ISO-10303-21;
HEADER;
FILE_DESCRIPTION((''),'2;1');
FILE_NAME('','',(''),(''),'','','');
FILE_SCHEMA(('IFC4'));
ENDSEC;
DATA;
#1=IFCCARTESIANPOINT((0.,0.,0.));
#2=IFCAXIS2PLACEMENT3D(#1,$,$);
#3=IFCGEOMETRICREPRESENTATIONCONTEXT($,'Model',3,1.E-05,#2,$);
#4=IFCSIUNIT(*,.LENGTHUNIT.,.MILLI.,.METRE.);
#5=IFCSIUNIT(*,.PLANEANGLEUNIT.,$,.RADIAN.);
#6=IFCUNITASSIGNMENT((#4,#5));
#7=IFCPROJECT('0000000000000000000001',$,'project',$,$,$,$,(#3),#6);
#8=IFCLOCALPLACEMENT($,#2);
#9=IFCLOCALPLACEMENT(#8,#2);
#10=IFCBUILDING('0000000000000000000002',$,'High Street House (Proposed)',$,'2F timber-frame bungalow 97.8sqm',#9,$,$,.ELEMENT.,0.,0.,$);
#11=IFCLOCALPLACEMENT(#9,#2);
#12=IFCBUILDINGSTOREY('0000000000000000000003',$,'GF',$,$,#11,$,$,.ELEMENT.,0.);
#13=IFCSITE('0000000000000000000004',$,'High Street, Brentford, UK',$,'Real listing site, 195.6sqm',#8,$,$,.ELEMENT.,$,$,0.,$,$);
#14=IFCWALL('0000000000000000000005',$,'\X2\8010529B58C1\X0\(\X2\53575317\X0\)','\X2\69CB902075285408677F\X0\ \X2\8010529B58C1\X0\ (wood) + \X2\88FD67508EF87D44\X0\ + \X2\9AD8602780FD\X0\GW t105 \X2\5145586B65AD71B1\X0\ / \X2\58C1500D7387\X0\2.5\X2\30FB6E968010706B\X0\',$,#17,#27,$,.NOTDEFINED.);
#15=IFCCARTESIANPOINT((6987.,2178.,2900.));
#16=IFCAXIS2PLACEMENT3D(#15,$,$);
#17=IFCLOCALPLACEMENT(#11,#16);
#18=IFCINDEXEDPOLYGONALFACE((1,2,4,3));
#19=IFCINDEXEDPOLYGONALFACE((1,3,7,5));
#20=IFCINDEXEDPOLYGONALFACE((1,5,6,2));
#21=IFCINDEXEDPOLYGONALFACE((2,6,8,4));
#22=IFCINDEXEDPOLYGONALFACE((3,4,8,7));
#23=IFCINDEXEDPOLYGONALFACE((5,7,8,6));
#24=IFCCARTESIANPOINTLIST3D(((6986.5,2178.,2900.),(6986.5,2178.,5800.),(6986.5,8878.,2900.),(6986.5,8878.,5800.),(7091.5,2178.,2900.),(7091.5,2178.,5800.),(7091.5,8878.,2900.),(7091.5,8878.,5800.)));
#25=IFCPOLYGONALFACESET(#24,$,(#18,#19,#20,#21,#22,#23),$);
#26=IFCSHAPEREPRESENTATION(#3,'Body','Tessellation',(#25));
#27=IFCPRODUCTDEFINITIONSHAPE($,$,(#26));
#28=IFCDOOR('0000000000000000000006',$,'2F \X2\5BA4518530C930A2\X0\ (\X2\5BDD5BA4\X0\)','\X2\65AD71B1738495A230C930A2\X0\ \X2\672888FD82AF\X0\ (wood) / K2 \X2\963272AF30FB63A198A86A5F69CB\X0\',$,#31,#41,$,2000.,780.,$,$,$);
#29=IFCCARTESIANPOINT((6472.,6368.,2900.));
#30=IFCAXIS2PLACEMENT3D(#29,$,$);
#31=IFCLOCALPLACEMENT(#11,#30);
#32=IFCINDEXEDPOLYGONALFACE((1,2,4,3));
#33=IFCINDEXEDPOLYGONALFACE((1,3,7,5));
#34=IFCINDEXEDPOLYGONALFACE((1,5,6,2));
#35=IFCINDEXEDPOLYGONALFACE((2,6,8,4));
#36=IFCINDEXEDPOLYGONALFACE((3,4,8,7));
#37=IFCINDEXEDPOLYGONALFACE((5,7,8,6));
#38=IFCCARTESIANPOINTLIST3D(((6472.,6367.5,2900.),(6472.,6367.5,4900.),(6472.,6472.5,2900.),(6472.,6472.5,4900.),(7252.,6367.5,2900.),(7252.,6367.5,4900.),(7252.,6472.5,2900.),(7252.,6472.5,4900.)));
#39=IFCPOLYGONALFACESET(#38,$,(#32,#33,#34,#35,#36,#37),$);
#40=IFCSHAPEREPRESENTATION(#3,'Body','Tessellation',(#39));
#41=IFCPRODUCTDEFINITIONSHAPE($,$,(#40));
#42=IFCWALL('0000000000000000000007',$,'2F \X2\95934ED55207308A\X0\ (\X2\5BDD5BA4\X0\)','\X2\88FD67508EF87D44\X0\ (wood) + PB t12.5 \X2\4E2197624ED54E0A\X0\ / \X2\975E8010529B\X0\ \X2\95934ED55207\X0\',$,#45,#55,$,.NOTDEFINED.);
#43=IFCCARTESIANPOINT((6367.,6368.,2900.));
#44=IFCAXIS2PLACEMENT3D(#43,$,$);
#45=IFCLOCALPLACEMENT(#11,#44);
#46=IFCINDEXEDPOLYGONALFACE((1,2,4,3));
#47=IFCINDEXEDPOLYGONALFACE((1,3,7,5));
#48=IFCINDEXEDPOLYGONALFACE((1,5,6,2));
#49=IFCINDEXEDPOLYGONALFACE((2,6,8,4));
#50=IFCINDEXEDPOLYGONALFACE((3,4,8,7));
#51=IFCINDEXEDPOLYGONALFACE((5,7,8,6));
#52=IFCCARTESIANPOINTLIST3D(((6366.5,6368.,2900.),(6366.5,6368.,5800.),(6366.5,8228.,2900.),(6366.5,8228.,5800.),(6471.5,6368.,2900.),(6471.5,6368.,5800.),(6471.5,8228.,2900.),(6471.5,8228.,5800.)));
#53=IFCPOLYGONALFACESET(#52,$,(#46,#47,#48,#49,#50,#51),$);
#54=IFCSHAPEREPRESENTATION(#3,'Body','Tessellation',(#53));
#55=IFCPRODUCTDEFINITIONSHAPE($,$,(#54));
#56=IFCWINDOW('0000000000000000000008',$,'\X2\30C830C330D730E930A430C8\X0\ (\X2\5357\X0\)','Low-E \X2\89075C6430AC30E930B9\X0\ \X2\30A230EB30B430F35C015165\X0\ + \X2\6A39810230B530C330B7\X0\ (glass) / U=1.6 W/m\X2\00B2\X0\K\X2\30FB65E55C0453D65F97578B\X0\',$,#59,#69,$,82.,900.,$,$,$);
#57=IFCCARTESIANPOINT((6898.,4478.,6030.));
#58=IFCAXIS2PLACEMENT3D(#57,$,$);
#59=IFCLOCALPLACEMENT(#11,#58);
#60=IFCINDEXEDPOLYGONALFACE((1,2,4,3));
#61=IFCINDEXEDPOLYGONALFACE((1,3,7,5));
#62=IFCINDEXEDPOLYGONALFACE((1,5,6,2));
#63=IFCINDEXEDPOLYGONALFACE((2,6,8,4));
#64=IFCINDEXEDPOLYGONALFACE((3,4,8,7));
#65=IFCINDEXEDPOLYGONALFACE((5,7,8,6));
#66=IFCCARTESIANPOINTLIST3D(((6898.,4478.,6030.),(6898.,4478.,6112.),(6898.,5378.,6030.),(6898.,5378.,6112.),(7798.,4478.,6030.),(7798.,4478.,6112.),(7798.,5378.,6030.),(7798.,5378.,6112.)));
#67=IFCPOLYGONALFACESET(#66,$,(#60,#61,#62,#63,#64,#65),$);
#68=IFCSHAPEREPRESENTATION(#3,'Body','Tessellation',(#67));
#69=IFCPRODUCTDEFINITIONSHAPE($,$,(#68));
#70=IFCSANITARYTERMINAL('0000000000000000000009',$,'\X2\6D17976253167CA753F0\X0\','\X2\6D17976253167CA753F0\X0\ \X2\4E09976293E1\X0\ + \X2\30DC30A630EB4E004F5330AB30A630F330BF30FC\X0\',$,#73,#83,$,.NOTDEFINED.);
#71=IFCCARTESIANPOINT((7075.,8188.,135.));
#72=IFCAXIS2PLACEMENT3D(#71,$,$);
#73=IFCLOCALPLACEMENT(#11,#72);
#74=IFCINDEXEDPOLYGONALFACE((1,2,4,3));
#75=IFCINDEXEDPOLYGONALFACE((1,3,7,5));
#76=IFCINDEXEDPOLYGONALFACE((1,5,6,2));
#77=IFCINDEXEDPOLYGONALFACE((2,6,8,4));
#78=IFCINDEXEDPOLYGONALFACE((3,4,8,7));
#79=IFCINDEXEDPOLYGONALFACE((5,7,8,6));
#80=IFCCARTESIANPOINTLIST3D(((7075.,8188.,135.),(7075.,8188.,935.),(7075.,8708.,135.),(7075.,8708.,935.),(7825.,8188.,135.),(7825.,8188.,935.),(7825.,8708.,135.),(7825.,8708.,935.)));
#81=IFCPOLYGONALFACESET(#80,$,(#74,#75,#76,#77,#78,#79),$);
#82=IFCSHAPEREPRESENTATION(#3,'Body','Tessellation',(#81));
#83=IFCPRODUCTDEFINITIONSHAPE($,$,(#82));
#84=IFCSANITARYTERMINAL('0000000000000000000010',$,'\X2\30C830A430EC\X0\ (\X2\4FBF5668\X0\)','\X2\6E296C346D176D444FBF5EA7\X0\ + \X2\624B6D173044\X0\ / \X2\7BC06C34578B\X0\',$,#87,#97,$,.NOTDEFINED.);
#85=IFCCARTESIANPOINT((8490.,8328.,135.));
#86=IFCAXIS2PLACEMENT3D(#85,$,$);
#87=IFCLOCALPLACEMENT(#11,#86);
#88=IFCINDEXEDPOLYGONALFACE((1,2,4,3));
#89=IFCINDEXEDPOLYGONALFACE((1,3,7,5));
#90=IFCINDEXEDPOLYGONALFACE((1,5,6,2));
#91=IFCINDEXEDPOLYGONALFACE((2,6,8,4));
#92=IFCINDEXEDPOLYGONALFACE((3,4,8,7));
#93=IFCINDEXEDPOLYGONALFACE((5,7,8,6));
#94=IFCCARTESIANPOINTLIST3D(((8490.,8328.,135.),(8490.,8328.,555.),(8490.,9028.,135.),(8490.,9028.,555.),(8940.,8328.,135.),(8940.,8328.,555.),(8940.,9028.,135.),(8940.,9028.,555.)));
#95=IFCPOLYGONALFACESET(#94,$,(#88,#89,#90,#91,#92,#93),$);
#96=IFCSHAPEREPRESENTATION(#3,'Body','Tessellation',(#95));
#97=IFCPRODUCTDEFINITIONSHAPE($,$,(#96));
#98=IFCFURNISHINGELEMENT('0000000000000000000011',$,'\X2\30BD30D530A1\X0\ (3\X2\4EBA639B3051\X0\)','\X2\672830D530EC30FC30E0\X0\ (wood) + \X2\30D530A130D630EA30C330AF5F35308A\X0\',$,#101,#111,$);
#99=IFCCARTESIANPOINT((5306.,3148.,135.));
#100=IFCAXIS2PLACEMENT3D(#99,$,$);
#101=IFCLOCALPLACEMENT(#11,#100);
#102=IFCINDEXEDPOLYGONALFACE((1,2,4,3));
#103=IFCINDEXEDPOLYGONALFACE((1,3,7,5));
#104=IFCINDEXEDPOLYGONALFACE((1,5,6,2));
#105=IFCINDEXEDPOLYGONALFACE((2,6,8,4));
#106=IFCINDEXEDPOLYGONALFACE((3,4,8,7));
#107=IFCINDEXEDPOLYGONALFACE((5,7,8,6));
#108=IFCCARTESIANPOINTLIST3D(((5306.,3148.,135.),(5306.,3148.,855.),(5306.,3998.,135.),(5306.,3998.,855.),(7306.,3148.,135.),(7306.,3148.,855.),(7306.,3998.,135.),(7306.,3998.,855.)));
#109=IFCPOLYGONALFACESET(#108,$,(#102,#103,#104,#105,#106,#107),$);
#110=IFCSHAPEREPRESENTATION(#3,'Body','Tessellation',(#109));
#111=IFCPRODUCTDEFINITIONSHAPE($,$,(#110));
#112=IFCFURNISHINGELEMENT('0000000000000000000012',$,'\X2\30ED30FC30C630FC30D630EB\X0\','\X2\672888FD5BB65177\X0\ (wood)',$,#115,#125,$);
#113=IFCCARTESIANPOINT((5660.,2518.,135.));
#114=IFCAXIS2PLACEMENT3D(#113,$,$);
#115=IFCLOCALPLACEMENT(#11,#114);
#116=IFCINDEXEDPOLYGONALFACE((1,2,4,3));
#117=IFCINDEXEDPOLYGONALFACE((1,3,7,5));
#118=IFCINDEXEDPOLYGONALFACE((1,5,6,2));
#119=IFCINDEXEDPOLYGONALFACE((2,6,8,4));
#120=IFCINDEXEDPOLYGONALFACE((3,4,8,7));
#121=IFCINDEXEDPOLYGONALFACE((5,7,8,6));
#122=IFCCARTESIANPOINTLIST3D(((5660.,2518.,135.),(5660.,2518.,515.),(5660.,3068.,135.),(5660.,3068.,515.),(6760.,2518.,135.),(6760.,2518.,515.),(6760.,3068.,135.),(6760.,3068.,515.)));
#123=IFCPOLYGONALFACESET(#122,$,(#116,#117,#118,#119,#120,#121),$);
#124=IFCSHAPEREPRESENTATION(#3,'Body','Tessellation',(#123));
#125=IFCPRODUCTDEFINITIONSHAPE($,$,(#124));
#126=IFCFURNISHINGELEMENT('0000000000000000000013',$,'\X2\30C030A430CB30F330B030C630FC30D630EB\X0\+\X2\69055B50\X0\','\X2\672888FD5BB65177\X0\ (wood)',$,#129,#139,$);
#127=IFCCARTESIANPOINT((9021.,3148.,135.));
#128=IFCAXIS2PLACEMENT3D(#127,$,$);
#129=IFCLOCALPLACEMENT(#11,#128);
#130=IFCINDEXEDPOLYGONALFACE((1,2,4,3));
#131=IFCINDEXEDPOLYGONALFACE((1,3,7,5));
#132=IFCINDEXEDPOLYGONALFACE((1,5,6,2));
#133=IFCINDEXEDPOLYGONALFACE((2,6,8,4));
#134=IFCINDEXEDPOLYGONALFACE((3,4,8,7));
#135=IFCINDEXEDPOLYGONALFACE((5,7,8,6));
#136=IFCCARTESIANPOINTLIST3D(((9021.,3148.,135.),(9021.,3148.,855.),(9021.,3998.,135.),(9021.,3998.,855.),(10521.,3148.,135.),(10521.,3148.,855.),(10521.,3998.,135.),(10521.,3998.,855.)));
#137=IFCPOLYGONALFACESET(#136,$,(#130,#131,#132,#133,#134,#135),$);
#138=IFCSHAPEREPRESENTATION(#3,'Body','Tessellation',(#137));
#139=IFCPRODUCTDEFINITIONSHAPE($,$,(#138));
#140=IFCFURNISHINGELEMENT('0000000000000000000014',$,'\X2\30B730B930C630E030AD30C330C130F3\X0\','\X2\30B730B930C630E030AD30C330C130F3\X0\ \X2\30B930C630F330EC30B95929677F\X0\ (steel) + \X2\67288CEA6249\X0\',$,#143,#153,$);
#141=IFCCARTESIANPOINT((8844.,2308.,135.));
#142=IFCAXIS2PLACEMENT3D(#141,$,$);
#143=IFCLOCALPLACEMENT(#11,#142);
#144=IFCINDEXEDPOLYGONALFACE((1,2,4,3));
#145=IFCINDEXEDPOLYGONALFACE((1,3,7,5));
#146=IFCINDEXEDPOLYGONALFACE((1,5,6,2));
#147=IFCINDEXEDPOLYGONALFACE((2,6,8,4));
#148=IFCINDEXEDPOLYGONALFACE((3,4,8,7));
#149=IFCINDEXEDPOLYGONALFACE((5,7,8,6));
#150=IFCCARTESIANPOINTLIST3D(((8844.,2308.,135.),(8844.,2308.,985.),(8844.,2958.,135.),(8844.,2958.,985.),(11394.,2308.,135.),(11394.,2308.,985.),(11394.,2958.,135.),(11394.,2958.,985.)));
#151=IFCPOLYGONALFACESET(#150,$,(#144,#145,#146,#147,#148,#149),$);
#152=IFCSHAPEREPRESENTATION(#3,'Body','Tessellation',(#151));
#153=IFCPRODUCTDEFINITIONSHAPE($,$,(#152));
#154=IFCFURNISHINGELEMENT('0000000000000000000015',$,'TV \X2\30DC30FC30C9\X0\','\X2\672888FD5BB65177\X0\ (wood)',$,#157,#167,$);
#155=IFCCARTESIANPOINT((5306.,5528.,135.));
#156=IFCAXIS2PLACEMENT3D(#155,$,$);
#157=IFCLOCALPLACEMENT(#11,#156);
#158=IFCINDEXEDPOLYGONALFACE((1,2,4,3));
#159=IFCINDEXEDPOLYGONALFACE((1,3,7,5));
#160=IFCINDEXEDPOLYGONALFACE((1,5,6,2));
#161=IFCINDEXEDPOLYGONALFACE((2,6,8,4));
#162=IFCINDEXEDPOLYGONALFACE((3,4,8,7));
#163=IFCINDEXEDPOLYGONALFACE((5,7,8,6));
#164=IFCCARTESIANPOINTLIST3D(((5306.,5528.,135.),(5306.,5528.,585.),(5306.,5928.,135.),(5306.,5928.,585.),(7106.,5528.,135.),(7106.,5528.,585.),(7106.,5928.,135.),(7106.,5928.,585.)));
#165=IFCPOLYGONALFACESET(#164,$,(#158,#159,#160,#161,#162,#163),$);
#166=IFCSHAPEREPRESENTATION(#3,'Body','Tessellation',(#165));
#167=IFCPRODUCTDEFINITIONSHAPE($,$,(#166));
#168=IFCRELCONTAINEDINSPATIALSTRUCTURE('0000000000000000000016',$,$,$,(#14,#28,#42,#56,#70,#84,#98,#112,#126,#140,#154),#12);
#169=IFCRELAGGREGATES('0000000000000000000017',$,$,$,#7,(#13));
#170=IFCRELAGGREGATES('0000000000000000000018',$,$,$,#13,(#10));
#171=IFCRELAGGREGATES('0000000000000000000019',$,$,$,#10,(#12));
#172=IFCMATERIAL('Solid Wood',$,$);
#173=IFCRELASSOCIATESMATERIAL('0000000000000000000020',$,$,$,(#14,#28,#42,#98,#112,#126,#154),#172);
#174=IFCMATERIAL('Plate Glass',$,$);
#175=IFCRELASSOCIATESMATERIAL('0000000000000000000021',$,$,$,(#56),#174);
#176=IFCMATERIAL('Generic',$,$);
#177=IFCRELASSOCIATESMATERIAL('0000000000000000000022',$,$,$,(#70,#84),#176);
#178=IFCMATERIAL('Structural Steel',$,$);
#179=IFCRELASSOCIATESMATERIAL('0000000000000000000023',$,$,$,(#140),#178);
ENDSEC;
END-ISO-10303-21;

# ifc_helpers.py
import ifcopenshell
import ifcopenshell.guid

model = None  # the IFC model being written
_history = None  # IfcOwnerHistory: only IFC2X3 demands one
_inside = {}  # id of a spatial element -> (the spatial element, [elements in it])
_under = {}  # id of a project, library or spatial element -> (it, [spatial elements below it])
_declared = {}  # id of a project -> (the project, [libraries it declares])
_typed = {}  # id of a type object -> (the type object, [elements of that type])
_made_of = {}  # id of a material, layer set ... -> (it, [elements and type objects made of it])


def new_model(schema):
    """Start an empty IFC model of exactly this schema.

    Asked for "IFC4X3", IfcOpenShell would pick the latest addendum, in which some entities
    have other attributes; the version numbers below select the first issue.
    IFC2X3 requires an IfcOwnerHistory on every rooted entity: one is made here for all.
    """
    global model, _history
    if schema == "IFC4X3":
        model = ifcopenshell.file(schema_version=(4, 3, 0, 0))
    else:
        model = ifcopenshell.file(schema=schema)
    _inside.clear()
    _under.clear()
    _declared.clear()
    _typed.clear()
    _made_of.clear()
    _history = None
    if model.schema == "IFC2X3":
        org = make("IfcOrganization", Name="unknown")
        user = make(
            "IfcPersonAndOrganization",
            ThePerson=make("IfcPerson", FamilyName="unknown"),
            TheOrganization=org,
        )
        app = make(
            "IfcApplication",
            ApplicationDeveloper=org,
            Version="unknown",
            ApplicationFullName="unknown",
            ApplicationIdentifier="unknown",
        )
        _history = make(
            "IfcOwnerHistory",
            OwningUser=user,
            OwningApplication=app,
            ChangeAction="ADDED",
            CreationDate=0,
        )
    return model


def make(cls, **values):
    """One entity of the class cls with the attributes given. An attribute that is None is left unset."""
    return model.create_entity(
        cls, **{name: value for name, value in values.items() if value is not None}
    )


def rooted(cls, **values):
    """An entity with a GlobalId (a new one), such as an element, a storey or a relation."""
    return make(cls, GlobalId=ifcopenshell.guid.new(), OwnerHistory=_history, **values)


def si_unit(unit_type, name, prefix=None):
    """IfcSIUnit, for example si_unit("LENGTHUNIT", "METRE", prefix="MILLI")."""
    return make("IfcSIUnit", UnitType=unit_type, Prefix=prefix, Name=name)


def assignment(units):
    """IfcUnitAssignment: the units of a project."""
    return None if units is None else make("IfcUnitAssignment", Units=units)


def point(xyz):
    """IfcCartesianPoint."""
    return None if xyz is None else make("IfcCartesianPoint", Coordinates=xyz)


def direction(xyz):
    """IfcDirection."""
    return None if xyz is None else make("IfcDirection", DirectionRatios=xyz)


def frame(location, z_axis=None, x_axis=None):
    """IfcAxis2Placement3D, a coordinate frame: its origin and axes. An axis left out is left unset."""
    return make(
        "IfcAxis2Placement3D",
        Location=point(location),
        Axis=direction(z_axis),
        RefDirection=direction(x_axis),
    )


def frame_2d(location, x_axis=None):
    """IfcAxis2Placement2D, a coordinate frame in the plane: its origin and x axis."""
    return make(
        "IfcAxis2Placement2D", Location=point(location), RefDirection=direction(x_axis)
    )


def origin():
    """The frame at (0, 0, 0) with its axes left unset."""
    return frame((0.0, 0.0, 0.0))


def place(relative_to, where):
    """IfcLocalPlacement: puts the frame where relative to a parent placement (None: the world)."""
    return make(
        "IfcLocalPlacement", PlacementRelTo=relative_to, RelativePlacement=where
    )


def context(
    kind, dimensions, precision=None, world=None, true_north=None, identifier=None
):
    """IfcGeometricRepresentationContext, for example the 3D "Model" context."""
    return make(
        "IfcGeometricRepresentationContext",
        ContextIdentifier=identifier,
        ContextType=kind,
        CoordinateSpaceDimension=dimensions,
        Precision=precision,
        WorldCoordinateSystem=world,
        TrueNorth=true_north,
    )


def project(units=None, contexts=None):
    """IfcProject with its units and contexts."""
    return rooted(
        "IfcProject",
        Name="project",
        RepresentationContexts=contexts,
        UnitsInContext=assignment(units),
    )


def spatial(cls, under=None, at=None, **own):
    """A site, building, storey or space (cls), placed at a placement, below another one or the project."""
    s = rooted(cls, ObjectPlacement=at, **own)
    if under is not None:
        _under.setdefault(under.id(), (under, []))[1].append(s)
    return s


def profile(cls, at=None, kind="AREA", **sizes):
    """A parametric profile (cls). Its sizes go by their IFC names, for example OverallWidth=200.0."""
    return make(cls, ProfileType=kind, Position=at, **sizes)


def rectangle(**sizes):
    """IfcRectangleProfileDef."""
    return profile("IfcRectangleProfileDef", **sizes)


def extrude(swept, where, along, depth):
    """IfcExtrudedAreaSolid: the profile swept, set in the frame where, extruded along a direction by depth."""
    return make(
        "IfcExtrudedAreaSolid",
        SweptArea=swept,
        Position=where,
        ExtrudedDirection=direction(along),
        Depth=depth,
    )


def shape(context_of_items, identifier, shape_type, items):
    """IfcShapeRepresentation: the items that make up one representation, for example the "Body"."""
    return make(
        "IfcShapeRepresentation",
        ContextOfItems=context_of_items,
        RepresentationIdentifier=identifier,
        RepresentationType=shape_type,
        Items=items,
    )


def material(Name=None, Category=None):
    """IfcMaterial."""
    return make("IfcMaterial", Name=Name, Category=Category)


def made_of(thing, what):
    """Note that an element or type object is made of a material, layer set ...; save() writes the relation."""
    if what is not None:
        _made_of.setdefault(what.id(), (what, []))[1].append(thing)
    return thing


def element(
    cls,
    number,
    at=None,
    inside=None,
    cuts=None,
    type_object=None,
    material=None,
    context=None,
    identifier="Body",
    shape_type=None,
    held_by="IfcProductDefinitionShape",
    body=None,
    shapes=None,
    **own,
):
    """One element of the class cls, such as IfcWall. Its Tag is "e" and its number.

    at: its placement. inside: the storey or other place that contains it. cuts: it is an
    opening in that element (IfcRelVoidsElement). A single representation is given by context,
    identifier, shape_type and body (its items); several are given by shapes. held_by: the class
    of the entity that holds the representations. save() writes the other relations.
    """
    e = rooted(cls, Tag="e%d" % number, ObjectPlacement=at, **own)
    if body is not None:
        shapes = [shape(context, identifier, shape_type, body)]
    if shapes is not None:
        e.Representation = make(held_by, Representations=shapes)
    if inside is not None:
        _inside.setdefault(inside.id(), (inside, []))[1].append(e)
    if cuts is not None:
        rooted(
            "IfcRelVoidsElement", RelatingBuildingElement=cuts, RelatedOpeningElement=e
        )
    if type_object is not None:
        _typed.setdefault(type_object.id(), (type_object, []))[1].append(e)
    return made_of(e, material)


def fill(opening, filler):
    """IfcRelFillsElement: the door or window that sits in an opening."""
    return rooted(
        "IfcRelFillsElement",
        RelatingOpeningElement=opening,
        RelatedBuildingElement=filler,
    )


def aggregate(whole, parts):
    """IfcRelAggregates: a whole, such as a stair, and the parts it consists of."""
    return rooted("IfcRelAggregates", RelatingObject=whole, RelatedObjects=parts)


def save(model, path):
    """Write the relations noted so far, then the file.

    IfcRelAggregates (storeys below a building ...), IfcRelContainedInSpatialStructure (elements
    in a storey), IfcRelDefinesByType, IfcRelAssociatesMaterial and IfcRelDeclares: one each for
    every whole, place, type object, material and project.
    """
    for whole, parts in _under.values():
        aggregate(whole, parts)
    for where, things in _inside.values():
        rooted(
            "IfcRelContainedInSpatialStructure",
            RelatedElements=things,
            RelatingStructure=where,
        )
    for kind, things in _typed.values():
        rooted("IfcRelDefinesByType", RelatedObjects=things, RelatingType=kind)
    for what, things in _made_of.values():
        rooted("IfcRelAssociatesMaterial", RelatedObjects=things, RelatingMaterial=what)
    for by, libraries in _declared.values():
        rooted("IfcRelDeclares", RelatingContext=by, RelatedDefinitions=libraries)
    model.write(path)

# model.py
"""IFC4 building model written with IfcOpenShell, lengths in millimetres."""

from ifc_helpers import new_model, si_unit, frame, frame_2d, origin, place, context, project, spatial, rectangle, extrude, material, element, fill, save


model = new_model("IFC4")

# Units and contexts
model_context = context("Model", 3, precision=1e-05, world=origin())
ifc_project = project(units=[si_unit("LENGTHUNIT", "METRE", prefix="MILLI"), si_unit("PLANEANGLEUNIT", "RADIAN")], contexts=[model_context])

# Site, building, storey
site_placement = place(None, origin())
site = spatial("IfcSite", under=ifc_project, at=site_placement, Name="High Street, Brentford, UK", ObjectType="Real listing site, 195.6sqm", CompositionType="ELEMENT", RefElevation=0.0)
building_placement = place(site_placement, origin())
building = spatial("IfcBuilding", under=site, at=building_placement, Name="High Street House (Proposed)", ObjectType="2F timber-frame bungalow 97.8sqm", CompositionType="ELEMENT", ElevationOfRefHeight=0.0, ElevationOfTerrain=0.0)
storey_placement = place(building_placement, origin())
storey = spatial("IfcBuildingStorey", under=building, at=storey_placement, Name="GF", CompositionType="ELEMENT", Elevation=0.0)

# Shared definitions
ifc_material_1 = material(Name="Solid Wood")

# Wall, opening, door
wall_1_placement = place(storey_placement, frame((6987.0, 2178.0, 2900.0)))
wall_1 = element("IfcWall", 1, at=wall_1_placement, inside=storey, material=ifc_material_1, Name="耐力壁(南北)", Description="構造用合板 耐力壁 (wood) + 製材軸組 + 高性能GW t105 充填断熱 / 壁倍率2.5・準耐火", PredefinedType="NOTDEFINED", context=model_context, shape_type="SweptSolid", body=[
    extrude(rectangle(XDim=105.0, YDim=6700.0, at=frame_2d((52.0, 3350.0))), frame((6987.0, 2178.0, 2900.0)), (0.0, 0.0, 1.0), 2900.0),
])
opening_1_placement = place(storey_placement, frame((6472.0, 6368.0, 2900.0)))
opening_1 = element("IfcOpeningElement", 2, at=opening_1_placement, cuts=wall_1, PredefinedType="NOTDEFINED", context=model_context, shape_type="SweptSolid", body=[
    extrude(rectangle(XDim=780.0, YDim=105.0, at=frame_2d((390.0, 52.0))), frame((6472.0, 6368.0, 2900.0)), (0.0, 0.0, 1.0), 2000.0),
])
door_1_placement = place(storey_placement, frame((6472.0, 6368.0, 2900.0)))
door_1 = element("IfcDoor", 3, at=door_1_placement, inside=storey, material=ifc_material_1, Name="2F 室内ドア (寝室)", Description="断熱玄関ドア 木製芯 (wood) / K2 防犯・採風機構", OverallHeight=2000.0, OverallWidth=780.0, context=model_context, shape_type="SweptSolid", body=[
    extrude(rectangle(XDim=780.0, YDim=105.0, at=frame_2d((390.0, 52.0))), frame((6472.0, 6368.0, 2900.0)), (0.0, 0.0, 1.0), 2000.0),
])
fill(opening_1, door_1)

# Wall
wall_2_placement = place(storey_placement, frame((6367.0, 6368.0, 2900.0)))
element("IfcWall", 4, at=wall_2_placement, inside=storey, material=ifc_material_1, Name="2F 間仕切り (寝室)", Description="製材軸組 (wood) + PB t12.5 両面仕上 / 非耐力 間仕切", PredefinedType="NOTDEFINED", context=model_context, shape_type="SweptSolid", body=[
    extrude(rectangle(XDim=105.0, YDim=1860.0, at=frame_2d((52.0, 930.0))), frame((6367.0, 6368.0, 2900.0)), (0.0, 0.0, 1.0), 2900.0),
])

# Window
ifc_material_2 = material(Name="Plate Glass")
window_placement = place(storey_placement, frame((6898.0, 4478.0, 6030.0)))
element("IfcWindow", 5, at=window_placement, inside=storey, material=ifc_material_2, Name="トップライト (南)", Description="Low-E 複層ガラス アルゴン封入 + 樹脂サッシ (glass) / U=1.6 W/m²K・日射取得型", OverallHeight=82.0, OverallWidth=900.0, context=model_context, shape_type="SweptSolid", body=[
    extrude(rectangle(XDim=900.0, YDim=900.0, at=frame_2d((450.0, 450.0))), frame((6898.0, 4478.0, 6030.0)), (0.0, 0.0, 1.0), 82.0),
])

# Sanitary terminals
ifc_material_3 = material(Name="Generic")
sanitary_terminal_1_placement = place(storey_placement, frame((7075.0, 8188.0, 135.0)))
element("IfcSanitaryTerminal", 6, at=sanitary_terminal_1_placement, inside=storey, material=ifc_material_3, Name="洗面化粧台", Description="洗面化粧台 三面鏡 + ボウル一体カウンター", PredefinedType="NOTDEFINED", context=model_context, shape_type="SweptSolid", body=[
    extrude(rectangle(XDim=750.0, YDim=520.0, at=frame_2d((375.0, 260.0))), frame((7075.0, 8188.0, 135.0)), (0.0, 0.0, 1.0), 800.0),
])
sanitary_terminal_2_placement = place(storey_placement, frame((8490.0, 8328.0, 135.0)))
element("IfcSanitaryTerminal", 7, at=sanitary_terminal_2_placement, inside=storey, material=ifc_material_3, Name="トイレ (便器)", Description="温水洗浄便座 + 手洗い / 節水型", PredefinedType="NOTDEFINED", context=model_context, shape_type="SweptSolid", body=[
    extrude(rectangle(XDim=450.0, YDim=700.0, at=frame_2d((225.0, 350.0))), frame((8490.0, 8328.0, 135.0)), (0.0, 0.0, 1.0), 420.0),
])

# Furnishing elements
furnishing_1_placement = place(storey_placement, frame((5306.0, 3148.0, 135.0)))
element("IfcFurnishingElement", 8, at=furnishing_1_placement, inside=storey, material=ifc_material_1, Name="ソファ (3人掛け)", Description="木フレーム (wood) + ファブリック張り", context=model_context, shape_type="SweptSolid", body=[
    extrude(rectangle(XDim=2000.0, YDim=850.0, at=frame_2d((1000.0, 425.0))), frame((5306.0, 3148.0, 135.0)), (0.0, 0.0, 1.0), 720.0),
])
furnishing_2_placement = place(storey_placement, frame((5660.0, 2518.0, 135.0)))
element("IfcFurnishingElement", 9, at=furnishing_2_placement, inside=storey, material=ifc_material_1, Name="ローテーブル", Description="木製家具 (wood)", context=model_context, shape_type="SweptSolid", body=[
    extrude(rectangle(XDim=1100.0, YDim=550.0, at=frame_2d((550.0, 275.0))), frame((5660.0, 2518.0, 135.0)), (0.0, 0.0, 1.0), 380.0),
])
furnishing_3_placement = place(storey_placement, frame((9021.0, 3148.0, 135.0)))
element("IfcFurnishingElement", 10, at=furnishing_3_placement, inside=storey, material=ifc_material_1, Name="ダイニングテーブル+椅子", Description="木製家具 (wood)", context=model_context, shape_type="SweptSolid", body=[
    extrude(rectangle(XDim=1500.0, YDim=850.0, at=frame_2d((750.0, 425.0))), frame((9021.0, 3148.0, 135.0)), (0.0, 0.0, 1.0), 720.0),
])
ifc_material_4 = material(Name="Structural Steel")
furnishing_4_placement = place(storey_placement, frame((8844.0, 2308.0, 135.0)))
element("IfcFurnishingElement", 11, at=furnishing_4_placement, inside=storey, material=ifc_material_4, Name="システムキッチン", Description="システムキッチン ステンレス天板 (steel) + 木質扉", context=model_context, shape_type="SweptSolid", body=[
    extrude(rectangle(XDim=2550.0, YDim=650.0, at=frame_2d((1275.0, 325.0))), frame((8844.0, 2308.0, 135.0)), (0.0, 0.0, 1.0), 850.0),
])
furnishing_5_placement = place(storey_placement, frame((5306.0, 5528.0, 135.0)))
element("IfcFurnishingElement", 12, at=furnishing_5_placement, inside=storey, material=ifc_material_1, Name="TV ボード", Description="木製家具 (wood)", context=model_context, shape_type="SweptSolid", body=[
    extrude(rectangle(XDim=1800.0, YDim=400.0, at=frame_2d((900.0, 200.0))), frame((5306.0, 5528.0, 135.0)), (0.0, 0.0, 1.0), 450.0),
])

save(model, "model.ifc")
